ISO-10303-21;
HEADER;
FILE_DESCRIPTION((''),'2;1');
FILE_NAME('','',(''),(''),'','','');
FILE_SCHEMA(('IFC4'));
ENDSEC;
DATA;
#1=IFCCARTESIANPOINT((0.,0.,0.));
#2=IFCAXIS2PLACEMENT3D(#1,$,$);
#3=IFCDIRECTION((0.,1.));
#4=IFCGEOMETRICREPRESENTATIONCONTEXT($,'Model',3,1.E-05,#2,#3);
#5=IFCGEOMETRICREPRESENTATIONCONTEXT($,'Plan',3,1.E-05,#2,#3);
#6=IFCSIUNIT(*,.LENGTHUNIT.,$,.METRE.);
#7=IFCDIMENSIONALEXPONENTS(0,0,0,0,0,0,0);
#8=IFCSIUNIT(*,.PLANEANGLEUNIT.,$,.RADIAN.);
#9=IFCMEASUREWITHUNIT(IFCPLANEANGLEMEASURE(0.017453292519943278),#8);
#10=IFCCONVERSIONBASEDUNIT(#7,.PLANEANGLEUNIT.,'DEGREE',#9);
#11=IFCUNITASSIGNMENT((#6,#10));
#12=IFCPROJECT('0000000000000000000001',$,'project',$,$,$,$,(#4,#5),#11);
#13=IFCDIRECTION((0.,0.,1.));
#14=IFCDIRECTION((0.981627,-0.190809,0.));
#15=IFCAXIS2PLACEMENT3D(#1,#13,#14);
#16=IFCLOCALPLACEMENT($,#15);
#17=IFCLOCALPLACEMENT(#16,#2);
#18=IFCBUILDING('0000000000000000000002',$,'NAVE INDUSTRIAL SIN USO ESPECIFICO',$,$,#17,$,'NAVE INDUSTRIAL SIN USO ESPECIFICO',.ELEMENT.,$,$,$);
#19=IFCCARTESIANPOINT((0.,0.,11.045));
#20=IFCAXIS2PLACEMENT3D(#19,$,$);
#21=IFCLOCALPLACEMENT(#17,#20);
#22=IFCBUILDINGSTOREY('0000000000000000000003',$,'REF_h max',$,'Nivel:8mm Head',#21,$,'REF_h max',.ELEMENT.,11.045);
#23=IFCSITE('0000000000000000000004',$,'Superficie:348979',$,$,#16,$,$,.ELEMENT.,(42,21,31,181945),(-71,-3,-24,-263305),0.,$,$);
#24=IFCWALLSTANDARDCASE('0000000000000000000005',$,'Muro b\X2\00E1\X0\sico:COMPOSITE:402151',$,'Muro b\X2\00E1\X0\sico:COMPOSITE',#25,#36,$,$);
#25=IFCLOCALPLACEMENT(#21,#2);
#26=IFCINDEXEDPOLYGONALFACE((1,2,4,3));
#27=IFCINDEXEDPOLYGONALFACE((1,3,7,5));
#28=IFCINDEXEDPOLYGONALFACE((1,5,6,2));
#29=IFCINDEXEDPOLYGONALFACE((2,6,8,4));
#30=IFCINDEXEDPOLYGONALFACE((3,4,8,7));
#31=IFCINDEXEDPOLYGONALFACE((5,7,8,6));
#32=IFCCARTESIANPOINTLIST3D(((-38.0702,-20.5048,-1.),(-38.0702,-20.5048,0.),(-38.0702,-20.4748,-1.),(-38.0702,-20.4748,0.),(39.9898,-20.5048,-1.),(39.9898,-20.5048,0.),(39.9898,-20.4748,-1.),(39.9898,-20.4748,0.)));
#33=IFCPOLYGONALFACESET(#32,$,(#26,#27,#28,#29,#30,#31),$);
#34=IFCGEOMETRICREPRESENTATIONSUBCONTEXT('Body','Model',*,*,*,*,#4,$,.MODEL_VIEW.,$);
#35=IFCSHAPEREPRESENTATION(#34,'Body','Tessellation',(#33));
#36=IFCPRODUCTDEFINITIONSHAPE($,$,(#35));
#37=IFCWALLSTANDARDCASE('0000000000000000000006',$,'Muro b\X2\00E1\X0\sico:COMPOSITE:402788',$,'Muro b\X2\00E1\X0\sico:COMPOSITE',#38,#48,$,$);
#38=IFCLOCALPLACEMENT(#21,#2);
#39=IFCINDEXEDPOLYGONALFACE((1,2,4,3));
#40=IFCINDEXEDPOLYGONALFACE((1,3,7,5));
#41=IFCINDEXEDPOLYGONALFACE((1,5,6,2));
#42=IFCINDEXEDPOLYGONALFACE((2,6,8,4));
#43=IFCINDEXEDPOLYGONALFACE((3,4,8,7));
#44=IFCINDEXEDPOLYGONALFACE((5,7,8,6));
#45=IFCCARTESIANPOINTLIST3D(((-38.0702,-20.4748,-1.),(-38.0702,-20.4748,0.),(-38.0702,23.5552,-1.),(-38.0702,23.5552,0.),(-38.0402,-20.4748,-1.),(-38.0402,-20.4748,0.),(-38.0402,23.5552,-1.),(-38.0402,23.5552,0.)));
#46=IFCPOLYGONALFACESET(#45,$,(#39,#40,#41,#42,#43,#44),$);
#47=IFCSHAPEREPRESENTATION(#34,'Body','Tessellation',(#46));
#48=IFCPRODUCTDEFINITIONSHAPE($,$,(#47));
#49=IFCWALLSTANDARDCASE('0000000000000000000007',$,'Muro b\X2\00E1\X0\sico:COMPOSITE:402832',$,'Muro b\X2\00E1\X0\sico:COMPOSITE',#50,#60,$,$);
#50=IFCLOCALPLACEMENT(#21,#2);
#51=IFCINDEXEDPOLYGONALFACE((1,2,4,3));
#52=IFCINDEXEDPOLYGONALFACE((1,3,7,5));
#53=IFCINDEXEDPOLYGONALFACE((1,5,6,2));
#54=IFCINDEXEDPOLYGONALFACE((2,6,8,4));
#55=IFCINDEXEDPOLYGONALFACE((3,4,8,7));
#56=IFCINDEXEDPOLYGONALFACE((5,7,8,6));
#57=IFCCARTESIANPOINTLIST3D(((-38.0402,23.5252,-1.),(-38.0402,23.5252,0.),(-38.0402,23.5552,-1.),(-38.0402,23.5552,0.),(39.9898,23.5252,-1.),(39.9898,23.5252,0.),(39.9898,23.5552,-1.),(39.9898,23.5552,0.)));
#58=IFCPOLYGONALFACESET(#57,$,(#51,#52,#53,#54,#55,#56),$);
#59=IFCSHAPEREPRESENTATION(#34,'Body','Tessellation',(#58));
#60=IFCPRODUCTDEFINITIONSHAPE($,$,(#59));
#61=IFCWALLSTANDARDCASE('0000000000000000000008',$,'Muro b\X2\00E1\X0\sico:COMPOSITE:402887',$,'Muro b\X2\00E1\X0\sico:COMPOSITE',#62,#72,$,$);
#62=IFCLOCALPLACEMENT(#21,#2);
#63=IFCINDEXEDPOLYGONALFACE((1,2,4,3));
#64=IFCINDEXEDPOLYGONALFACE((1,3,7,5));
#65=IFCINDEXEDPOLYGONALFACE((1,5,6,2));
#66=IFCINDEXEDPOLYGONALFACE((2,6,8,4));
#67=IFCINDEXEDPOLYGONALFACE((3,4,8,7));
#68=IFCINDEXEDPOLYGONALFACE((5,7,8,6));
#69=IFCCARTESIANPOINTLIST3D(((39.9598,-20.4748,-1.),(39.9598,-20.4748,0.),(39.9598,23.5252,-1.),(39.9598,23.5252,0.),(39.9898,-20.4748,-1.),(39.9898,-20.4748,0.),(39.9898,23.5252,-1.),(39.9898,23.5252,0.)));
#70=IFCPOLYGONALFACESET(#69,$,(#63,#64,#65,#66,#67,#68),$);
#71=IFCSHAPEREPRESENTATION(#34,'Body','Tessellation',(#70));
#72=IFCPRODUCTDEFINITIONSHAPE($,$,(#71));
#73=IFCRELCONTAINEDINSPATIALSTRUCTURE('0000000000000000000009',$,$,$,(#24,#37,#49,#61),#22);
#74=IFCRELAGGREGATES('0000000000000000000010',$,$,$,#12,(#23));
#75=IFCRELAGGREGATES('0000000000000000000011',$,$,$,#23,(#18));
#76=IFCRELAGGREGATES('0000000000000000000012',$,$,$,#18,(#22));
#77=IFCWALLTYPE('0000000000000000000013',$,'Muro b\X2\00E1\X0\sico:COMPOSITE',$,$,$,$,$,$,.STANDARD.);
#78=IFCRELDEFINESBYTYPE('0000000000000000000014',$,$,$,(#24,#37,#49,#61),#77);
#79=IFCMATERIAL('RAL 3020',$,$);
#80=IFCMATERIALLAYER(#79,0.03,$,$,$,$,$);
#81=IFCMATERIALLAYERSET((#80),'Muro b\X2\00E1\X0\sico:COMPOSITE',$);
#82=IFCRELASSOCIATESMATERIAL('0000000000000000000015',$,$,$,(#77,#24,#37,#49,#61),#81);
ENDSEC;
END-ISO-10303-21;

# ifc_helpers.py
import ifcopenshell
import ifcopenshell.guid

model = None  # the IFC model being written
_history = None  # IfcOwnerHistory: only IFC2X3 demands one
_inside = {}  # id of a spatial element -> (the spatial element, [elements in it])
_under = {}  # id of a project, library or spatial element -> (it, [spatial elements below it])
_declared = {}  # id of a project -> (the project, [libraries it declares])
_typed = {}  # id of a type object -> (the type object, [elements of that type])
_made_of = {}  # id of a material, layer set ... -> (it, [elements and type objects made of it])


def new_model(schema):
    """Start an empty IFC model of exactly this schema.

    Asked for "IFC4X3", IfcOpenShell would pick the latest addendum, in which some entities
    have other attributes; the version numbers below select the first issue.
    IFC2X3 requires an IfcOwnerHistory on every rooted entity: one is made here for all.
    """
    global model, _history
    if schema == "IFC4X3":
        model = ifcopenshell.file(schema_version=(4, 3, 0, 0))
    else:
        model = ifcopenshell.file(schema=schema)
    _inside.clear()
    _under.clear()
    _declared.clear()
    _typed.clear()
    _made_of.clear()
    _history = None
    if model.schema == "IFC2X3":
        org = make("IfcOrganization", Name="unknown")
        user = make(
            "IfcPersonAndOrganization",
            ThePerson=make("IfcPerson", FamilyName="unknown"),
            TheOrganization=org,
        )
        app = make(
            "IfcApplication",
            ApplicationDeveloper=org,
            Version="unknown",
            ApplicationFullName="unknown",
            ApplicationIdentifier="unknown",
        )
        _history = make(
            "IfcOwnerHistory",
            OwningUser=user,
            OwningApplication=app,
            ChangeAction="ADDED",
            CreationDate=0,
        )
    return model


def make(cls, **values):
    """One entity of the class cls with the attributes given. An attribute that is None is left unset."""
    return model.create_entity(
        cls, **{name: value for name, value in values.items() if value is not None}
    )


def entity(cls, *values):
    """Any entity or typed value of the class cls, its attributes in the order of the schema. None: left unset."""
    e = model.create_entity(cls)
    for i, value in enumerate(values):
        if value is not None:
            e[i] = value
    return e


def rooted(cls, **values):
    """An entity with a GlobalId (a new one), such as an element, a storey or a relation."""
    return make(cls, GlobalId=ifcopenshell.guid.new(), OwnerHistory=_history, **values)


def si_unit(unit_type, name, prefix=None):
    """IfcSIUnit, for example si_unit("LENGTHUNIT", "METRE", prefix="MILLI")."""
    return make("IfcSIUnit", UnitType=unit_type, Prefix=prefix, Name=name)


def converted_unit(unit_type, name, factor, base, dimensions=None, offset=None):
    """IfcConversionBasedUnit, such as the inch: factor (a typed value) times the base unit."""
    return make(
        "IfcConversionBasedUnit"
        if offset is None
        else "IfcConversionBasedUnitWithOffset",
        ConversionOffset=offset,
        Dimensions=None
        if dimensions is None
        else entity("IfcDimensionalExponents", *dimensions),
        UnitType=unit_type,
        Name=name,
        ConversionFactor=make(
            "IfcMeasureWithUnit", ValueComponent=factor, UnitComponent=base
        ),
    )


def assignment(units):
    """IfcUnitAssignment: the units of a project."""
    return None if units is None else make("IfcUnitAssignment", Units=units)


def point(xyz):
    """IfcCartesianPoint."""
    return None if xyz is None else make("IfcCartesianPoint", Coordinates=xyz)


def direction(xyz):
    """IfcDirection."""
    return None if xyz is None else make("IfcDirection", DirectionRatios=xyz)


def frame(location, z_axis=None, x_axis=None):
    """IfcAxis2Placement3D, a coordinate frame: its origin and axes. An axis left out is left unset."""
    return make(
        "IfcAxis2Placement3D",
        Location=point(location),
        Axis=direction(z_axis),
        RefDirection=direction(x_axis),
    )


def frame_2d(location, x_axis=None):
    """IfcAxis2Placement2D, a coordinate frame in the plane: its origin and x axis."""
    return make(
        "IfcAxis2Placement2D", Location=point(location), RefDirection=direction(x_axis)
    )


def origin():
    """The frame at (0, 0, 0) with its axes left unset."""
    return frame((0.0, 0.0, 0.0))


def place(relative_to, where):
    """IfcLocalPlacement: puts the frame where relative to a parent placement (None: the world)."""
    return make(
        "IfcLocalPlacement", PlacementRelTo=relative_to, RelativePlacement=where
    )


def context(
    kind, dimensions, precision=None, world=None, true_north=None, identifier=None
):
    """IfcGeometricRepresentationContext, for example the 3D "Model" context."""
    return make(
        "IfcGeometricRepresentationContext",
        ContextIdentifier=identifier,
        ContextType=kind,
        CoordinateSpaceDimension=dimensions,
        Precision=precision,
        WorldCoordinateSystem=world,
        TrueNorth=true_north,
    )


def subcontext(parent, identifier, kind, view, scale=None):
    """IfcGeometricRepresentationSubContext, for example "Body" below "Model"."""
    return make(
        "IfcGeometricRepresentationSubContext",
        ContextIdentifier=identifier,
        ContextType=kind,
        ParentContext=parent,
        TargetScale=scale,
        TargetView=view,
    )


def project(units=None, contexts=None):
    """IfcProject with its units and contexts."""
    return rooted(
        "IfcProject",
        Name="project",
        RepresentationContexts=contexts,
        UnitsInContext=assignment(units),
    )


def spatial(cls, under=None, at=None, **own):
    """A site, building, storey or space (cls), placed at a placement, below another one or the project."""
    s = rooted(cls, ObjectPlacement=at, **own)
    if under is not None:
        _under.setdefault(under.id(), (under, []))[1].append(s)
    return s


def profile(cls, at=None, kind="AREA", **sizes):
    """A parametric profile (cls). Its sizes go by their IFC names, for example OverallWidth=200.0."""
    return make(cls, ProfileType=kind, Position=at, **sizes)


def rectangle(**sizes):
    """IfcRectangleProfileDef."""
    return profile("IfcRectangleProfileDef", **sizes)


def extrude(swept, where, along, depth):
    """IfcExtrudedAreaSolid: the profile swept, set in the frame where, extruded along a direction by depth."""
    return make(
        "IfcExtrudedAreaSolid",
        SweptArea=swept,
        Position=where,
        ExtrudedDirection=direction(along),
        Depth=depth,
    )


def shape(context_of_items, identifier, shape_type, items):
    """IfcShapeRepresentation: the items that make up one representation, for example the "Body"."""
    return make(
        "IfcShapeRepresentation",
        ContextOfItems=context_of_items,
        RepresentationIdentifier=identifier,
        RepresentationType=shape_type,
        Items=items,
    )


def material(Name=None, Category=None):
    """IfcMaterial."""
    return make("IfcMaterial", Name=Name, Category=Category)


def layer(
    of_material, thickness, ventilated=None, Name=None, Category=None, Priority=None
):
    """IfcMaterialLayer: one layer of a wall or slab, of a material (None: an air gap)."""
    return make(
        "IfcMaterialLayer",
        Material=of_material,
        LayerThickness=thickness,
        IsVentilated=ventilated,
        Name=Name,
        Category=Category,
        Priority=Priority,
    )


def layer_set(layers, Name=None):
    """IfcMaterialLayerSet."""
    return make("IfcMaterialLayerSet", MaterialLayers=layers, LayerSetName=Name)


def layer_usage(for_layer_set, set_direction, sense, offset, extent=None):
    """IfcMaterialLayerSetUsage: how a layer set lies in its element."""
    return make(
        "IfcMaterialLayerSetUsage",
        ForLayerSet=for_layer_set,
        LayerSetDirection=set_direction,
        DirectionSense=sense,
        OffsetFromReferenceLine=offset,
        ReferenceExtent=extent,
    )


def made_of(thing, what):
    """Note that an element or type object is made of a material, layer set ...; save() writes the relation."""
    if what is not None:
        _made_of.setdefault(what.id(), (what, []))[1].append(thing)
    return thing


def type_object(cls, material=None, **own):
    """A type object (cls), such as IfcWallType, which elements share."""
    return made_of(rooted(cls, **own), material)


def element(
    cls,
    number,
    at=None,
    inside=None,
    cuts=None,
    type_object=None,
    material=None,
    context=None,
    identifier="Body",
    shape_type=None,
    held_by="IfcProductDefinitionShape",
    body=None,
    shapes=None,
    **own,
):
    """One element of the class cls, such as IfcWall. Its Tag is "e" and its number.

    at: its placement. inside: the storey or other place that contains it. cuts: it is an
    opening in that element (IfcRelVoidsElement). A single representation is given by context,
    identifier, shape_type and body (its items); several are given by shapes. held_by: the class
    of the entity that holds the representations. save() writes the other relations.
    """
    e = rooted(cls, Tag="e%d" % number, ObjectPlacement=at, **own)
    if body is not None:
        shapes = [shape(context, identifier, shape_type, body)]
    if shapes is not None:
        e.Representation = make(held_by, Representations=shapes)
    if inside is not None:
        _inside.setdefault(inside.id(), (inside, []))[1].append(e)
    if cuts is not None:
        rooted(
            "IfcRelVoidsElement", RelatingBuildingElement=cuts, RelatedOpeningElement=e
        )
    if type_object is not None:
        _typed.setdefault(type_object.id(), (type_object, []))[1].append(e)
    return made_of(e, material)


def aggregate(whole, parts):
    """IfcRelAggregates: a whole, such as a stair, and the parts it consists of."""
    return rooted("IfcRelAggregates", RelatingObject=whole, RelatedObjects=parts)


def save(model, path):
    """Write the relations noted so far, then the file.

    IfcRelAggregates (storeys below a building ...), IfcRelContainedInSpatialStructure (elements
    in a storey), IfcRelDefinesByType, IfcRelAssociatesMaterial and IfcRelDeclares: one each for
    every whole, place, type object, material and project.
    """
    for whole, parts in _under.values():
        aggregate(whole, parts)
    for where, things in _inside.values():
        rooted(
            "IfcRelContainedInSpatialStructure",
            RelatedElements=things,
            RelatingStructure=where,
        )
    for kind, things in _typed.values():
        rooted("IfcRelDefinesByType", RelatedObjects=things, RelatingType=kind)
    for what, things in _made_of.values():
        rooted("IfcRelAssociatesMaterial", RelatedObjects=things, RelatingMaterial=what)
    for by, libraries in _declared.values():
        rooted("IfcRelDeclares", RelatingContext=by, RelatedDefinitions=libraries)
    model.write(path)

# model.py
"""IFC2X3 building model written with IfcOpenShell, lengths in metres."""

from ifc_helpers import new_model, entity, si_unit, converted_unit, direction, frame, frame_2d, origin, place, context, subcontext, project, spatial, rectangle, extrude, material, layer, layer_set, layer_usage, type_object, element, save


model = new_model("IFC2X3")

# Units and contexts
model_context = context("Model", 3, precision=1e-05, world=origin(), true_north=direction((0.0, 1.0)))
plan_context = context("Plan", 3, precision=1e-05, world=origin(), true_north=direction((0.0, 1.0)))
body_context = subcontext(model_context, "Body", "Model", "MODEL_VIEW")
ifc_project = project(units=[si_unit("LENGTHUNIT", "METRE"), converted_unit("PLANEANGLEUNIT", "DEGREE", entity("IfcPlaneAngleMeasure", 0.017453292519943278), si_unit("PLANEANGLEUNIT", "RADIAN"), dimensions=[0, 0, 0, 0, 0, 0, 0])], contexts=[model_context, plan_context])

# Site, building, storey
site_placement = place(None, frame((0.0, 0.0, 0.0), z_axis=(0.0, 0.0, 1.0), x_axis=(0.981627, -0.190809, 0.0)))
site = spatial("IfcSite", under=ifc_project, at=site_placement, Name="Superficie:348979", CompositionType="ELEMENT", RefLatitude=(42, 21, 31, 181945), RefLongitude=(-71, -3, -24, -263305), RefElevation=0.0)
building_placement = place(site_placement, origin())
building = spatial("IfcBuilding", under=site, at=building_placement, Name="NAVE INDUSTRIAL SIN USO ESPECIFICO", LongName="NAVE INDUSTRIAL SIN USO ESPECIFICO", CompositionType="ELEMENT")
storey_placement = place(building_placement, frame((0.0, 0.0, 11.045)))
storey = spatial("IfcBuildingStorey", under=building, at=storey_placement, Name="REF_h max", ObjectType="Nivel:8mm Head", LongName="REF_h max", CompositionType="ELEMENT", Elevation=11.045)

# Walls
ifc_material = material(Name="RAL 3020")
ifc_layer = layer(ifc_material, 0.03)
ifc_layer_set = layer_set([ifc_layer], Name="Muro básico:COMPOSITE")
ifc_layer_usage_1 = layer_usage(ifc_layer_set, "AXIS2", "NEGATIVE", 0.015)
wall_type = type_object("IfcWallType", Name="Muro básico:COMPOSITE", PredefinedType="STANDARD", material=ifc_layer_set)
wall_1_placement = place(storey_placement, frame((39.9898, -20.4898, -1.0), z_axis=(0.0, 0.0, 1.0), x_axis=(-1.0, 0.0, 0.0)))
element("IfcWallStandardCase", 1, at=wall_1_placement, inside=storey, type_object=wall_type, material=ifc_layer_usage_1, Name="Muro básico:COMPOSITE:402151", ObjectType="Muro básico:COMPOSITE", context=body_context, shape_type="SweptSolid", body=[
    extrude(rectangle(XDim=78.06, YDim=0.03, at=frame_2d((39.03, 0.0), x_axis=(-1.0, 0.0))), origin(), (0.0, 0.0, 1.0), 1.0),
])
ifc_layer_usage_2 = layer_usage(ifc_layer_set, "AXIS2", "POSITIVE", -0.015)
wall_2_placement = place(storey_placement, frame((-38.0552, 23.5552, -1.0), z_axis=(0.0, 0.0, 1.0), x_axis=(0.0, -1.0, 0.0)))
element("IfcWallStandardCase", 2, at=wall_2_placement, inside=storey, type_object=wall_type, material=ifc_layer_usage_2, Name="Muro básico:COMPOSITE:402788", ObjectType="Muro básico:COMPOSITE", context=body_context, shape_type="SweptSolid", body=[
    extrude(rectangle(XDim=44.03, YDim=0.03, at=frame_2d((22.015, 0.0), x_axis=(-1.0, 0.0))), origin(), (0.0, 0.0, 1.0), 1.0),
])
ifc_layer_usage_3 = layer_usage(ifc_layer_set, "AXIS2", "NEGATIVE", 0.015)
wall_3_placement = place(storey_placement, frame((-38.0402, 23.5402, -1.0)))
element("IfcWallStandardCase", 3, at=wall_3_placement, inside=storey, type_object=wall_type, material=ifc_layer_usage_3, Name="Muro básico:COMPOSITE:402832", ObjectType="Muro básico:COMPOSITE", context=body_context, shape_type="SweptSolid", body=[
    extrude(rectangle(XDim=78.03, YDim=0.03, at=frame_2d((39.015, 0.0), x_axis=(-1.0, 0.0))), origin(), (0.0, 0.0, 1.0), 1.0),
])
ifc_layer_usage_4 = layer_usage(ifc_layer_set, "AXIS2", "POSITIVE", -0.015)
wall_4_placement = place(storey_placement, frame((39.9748, -20.4748, -1.0), z_axis=(0.0, 0.0, 1.0), x_axis=(0.0, 1.0, 0.0)))
element("IfcWallStandardCase", 4, at=wall_4_placement, inside=storey, type_object=wall_type, material=ifc_layer_usage_4, Name="Muro básico:COMPOSITE:402887", ObjectType="Muro básico:COMPOSITE", context=body_context, shape_type="SweptSolid", body=[
    extrude(rectangle(XDim=44.0, YDim=0.03, at=frame_2d((22.0, 0.0), x_axis=(-1.0, 0.0))), origin(), (0.0, 0.0, 1.0), 1.0),
])

save(model, "model.ifc")
